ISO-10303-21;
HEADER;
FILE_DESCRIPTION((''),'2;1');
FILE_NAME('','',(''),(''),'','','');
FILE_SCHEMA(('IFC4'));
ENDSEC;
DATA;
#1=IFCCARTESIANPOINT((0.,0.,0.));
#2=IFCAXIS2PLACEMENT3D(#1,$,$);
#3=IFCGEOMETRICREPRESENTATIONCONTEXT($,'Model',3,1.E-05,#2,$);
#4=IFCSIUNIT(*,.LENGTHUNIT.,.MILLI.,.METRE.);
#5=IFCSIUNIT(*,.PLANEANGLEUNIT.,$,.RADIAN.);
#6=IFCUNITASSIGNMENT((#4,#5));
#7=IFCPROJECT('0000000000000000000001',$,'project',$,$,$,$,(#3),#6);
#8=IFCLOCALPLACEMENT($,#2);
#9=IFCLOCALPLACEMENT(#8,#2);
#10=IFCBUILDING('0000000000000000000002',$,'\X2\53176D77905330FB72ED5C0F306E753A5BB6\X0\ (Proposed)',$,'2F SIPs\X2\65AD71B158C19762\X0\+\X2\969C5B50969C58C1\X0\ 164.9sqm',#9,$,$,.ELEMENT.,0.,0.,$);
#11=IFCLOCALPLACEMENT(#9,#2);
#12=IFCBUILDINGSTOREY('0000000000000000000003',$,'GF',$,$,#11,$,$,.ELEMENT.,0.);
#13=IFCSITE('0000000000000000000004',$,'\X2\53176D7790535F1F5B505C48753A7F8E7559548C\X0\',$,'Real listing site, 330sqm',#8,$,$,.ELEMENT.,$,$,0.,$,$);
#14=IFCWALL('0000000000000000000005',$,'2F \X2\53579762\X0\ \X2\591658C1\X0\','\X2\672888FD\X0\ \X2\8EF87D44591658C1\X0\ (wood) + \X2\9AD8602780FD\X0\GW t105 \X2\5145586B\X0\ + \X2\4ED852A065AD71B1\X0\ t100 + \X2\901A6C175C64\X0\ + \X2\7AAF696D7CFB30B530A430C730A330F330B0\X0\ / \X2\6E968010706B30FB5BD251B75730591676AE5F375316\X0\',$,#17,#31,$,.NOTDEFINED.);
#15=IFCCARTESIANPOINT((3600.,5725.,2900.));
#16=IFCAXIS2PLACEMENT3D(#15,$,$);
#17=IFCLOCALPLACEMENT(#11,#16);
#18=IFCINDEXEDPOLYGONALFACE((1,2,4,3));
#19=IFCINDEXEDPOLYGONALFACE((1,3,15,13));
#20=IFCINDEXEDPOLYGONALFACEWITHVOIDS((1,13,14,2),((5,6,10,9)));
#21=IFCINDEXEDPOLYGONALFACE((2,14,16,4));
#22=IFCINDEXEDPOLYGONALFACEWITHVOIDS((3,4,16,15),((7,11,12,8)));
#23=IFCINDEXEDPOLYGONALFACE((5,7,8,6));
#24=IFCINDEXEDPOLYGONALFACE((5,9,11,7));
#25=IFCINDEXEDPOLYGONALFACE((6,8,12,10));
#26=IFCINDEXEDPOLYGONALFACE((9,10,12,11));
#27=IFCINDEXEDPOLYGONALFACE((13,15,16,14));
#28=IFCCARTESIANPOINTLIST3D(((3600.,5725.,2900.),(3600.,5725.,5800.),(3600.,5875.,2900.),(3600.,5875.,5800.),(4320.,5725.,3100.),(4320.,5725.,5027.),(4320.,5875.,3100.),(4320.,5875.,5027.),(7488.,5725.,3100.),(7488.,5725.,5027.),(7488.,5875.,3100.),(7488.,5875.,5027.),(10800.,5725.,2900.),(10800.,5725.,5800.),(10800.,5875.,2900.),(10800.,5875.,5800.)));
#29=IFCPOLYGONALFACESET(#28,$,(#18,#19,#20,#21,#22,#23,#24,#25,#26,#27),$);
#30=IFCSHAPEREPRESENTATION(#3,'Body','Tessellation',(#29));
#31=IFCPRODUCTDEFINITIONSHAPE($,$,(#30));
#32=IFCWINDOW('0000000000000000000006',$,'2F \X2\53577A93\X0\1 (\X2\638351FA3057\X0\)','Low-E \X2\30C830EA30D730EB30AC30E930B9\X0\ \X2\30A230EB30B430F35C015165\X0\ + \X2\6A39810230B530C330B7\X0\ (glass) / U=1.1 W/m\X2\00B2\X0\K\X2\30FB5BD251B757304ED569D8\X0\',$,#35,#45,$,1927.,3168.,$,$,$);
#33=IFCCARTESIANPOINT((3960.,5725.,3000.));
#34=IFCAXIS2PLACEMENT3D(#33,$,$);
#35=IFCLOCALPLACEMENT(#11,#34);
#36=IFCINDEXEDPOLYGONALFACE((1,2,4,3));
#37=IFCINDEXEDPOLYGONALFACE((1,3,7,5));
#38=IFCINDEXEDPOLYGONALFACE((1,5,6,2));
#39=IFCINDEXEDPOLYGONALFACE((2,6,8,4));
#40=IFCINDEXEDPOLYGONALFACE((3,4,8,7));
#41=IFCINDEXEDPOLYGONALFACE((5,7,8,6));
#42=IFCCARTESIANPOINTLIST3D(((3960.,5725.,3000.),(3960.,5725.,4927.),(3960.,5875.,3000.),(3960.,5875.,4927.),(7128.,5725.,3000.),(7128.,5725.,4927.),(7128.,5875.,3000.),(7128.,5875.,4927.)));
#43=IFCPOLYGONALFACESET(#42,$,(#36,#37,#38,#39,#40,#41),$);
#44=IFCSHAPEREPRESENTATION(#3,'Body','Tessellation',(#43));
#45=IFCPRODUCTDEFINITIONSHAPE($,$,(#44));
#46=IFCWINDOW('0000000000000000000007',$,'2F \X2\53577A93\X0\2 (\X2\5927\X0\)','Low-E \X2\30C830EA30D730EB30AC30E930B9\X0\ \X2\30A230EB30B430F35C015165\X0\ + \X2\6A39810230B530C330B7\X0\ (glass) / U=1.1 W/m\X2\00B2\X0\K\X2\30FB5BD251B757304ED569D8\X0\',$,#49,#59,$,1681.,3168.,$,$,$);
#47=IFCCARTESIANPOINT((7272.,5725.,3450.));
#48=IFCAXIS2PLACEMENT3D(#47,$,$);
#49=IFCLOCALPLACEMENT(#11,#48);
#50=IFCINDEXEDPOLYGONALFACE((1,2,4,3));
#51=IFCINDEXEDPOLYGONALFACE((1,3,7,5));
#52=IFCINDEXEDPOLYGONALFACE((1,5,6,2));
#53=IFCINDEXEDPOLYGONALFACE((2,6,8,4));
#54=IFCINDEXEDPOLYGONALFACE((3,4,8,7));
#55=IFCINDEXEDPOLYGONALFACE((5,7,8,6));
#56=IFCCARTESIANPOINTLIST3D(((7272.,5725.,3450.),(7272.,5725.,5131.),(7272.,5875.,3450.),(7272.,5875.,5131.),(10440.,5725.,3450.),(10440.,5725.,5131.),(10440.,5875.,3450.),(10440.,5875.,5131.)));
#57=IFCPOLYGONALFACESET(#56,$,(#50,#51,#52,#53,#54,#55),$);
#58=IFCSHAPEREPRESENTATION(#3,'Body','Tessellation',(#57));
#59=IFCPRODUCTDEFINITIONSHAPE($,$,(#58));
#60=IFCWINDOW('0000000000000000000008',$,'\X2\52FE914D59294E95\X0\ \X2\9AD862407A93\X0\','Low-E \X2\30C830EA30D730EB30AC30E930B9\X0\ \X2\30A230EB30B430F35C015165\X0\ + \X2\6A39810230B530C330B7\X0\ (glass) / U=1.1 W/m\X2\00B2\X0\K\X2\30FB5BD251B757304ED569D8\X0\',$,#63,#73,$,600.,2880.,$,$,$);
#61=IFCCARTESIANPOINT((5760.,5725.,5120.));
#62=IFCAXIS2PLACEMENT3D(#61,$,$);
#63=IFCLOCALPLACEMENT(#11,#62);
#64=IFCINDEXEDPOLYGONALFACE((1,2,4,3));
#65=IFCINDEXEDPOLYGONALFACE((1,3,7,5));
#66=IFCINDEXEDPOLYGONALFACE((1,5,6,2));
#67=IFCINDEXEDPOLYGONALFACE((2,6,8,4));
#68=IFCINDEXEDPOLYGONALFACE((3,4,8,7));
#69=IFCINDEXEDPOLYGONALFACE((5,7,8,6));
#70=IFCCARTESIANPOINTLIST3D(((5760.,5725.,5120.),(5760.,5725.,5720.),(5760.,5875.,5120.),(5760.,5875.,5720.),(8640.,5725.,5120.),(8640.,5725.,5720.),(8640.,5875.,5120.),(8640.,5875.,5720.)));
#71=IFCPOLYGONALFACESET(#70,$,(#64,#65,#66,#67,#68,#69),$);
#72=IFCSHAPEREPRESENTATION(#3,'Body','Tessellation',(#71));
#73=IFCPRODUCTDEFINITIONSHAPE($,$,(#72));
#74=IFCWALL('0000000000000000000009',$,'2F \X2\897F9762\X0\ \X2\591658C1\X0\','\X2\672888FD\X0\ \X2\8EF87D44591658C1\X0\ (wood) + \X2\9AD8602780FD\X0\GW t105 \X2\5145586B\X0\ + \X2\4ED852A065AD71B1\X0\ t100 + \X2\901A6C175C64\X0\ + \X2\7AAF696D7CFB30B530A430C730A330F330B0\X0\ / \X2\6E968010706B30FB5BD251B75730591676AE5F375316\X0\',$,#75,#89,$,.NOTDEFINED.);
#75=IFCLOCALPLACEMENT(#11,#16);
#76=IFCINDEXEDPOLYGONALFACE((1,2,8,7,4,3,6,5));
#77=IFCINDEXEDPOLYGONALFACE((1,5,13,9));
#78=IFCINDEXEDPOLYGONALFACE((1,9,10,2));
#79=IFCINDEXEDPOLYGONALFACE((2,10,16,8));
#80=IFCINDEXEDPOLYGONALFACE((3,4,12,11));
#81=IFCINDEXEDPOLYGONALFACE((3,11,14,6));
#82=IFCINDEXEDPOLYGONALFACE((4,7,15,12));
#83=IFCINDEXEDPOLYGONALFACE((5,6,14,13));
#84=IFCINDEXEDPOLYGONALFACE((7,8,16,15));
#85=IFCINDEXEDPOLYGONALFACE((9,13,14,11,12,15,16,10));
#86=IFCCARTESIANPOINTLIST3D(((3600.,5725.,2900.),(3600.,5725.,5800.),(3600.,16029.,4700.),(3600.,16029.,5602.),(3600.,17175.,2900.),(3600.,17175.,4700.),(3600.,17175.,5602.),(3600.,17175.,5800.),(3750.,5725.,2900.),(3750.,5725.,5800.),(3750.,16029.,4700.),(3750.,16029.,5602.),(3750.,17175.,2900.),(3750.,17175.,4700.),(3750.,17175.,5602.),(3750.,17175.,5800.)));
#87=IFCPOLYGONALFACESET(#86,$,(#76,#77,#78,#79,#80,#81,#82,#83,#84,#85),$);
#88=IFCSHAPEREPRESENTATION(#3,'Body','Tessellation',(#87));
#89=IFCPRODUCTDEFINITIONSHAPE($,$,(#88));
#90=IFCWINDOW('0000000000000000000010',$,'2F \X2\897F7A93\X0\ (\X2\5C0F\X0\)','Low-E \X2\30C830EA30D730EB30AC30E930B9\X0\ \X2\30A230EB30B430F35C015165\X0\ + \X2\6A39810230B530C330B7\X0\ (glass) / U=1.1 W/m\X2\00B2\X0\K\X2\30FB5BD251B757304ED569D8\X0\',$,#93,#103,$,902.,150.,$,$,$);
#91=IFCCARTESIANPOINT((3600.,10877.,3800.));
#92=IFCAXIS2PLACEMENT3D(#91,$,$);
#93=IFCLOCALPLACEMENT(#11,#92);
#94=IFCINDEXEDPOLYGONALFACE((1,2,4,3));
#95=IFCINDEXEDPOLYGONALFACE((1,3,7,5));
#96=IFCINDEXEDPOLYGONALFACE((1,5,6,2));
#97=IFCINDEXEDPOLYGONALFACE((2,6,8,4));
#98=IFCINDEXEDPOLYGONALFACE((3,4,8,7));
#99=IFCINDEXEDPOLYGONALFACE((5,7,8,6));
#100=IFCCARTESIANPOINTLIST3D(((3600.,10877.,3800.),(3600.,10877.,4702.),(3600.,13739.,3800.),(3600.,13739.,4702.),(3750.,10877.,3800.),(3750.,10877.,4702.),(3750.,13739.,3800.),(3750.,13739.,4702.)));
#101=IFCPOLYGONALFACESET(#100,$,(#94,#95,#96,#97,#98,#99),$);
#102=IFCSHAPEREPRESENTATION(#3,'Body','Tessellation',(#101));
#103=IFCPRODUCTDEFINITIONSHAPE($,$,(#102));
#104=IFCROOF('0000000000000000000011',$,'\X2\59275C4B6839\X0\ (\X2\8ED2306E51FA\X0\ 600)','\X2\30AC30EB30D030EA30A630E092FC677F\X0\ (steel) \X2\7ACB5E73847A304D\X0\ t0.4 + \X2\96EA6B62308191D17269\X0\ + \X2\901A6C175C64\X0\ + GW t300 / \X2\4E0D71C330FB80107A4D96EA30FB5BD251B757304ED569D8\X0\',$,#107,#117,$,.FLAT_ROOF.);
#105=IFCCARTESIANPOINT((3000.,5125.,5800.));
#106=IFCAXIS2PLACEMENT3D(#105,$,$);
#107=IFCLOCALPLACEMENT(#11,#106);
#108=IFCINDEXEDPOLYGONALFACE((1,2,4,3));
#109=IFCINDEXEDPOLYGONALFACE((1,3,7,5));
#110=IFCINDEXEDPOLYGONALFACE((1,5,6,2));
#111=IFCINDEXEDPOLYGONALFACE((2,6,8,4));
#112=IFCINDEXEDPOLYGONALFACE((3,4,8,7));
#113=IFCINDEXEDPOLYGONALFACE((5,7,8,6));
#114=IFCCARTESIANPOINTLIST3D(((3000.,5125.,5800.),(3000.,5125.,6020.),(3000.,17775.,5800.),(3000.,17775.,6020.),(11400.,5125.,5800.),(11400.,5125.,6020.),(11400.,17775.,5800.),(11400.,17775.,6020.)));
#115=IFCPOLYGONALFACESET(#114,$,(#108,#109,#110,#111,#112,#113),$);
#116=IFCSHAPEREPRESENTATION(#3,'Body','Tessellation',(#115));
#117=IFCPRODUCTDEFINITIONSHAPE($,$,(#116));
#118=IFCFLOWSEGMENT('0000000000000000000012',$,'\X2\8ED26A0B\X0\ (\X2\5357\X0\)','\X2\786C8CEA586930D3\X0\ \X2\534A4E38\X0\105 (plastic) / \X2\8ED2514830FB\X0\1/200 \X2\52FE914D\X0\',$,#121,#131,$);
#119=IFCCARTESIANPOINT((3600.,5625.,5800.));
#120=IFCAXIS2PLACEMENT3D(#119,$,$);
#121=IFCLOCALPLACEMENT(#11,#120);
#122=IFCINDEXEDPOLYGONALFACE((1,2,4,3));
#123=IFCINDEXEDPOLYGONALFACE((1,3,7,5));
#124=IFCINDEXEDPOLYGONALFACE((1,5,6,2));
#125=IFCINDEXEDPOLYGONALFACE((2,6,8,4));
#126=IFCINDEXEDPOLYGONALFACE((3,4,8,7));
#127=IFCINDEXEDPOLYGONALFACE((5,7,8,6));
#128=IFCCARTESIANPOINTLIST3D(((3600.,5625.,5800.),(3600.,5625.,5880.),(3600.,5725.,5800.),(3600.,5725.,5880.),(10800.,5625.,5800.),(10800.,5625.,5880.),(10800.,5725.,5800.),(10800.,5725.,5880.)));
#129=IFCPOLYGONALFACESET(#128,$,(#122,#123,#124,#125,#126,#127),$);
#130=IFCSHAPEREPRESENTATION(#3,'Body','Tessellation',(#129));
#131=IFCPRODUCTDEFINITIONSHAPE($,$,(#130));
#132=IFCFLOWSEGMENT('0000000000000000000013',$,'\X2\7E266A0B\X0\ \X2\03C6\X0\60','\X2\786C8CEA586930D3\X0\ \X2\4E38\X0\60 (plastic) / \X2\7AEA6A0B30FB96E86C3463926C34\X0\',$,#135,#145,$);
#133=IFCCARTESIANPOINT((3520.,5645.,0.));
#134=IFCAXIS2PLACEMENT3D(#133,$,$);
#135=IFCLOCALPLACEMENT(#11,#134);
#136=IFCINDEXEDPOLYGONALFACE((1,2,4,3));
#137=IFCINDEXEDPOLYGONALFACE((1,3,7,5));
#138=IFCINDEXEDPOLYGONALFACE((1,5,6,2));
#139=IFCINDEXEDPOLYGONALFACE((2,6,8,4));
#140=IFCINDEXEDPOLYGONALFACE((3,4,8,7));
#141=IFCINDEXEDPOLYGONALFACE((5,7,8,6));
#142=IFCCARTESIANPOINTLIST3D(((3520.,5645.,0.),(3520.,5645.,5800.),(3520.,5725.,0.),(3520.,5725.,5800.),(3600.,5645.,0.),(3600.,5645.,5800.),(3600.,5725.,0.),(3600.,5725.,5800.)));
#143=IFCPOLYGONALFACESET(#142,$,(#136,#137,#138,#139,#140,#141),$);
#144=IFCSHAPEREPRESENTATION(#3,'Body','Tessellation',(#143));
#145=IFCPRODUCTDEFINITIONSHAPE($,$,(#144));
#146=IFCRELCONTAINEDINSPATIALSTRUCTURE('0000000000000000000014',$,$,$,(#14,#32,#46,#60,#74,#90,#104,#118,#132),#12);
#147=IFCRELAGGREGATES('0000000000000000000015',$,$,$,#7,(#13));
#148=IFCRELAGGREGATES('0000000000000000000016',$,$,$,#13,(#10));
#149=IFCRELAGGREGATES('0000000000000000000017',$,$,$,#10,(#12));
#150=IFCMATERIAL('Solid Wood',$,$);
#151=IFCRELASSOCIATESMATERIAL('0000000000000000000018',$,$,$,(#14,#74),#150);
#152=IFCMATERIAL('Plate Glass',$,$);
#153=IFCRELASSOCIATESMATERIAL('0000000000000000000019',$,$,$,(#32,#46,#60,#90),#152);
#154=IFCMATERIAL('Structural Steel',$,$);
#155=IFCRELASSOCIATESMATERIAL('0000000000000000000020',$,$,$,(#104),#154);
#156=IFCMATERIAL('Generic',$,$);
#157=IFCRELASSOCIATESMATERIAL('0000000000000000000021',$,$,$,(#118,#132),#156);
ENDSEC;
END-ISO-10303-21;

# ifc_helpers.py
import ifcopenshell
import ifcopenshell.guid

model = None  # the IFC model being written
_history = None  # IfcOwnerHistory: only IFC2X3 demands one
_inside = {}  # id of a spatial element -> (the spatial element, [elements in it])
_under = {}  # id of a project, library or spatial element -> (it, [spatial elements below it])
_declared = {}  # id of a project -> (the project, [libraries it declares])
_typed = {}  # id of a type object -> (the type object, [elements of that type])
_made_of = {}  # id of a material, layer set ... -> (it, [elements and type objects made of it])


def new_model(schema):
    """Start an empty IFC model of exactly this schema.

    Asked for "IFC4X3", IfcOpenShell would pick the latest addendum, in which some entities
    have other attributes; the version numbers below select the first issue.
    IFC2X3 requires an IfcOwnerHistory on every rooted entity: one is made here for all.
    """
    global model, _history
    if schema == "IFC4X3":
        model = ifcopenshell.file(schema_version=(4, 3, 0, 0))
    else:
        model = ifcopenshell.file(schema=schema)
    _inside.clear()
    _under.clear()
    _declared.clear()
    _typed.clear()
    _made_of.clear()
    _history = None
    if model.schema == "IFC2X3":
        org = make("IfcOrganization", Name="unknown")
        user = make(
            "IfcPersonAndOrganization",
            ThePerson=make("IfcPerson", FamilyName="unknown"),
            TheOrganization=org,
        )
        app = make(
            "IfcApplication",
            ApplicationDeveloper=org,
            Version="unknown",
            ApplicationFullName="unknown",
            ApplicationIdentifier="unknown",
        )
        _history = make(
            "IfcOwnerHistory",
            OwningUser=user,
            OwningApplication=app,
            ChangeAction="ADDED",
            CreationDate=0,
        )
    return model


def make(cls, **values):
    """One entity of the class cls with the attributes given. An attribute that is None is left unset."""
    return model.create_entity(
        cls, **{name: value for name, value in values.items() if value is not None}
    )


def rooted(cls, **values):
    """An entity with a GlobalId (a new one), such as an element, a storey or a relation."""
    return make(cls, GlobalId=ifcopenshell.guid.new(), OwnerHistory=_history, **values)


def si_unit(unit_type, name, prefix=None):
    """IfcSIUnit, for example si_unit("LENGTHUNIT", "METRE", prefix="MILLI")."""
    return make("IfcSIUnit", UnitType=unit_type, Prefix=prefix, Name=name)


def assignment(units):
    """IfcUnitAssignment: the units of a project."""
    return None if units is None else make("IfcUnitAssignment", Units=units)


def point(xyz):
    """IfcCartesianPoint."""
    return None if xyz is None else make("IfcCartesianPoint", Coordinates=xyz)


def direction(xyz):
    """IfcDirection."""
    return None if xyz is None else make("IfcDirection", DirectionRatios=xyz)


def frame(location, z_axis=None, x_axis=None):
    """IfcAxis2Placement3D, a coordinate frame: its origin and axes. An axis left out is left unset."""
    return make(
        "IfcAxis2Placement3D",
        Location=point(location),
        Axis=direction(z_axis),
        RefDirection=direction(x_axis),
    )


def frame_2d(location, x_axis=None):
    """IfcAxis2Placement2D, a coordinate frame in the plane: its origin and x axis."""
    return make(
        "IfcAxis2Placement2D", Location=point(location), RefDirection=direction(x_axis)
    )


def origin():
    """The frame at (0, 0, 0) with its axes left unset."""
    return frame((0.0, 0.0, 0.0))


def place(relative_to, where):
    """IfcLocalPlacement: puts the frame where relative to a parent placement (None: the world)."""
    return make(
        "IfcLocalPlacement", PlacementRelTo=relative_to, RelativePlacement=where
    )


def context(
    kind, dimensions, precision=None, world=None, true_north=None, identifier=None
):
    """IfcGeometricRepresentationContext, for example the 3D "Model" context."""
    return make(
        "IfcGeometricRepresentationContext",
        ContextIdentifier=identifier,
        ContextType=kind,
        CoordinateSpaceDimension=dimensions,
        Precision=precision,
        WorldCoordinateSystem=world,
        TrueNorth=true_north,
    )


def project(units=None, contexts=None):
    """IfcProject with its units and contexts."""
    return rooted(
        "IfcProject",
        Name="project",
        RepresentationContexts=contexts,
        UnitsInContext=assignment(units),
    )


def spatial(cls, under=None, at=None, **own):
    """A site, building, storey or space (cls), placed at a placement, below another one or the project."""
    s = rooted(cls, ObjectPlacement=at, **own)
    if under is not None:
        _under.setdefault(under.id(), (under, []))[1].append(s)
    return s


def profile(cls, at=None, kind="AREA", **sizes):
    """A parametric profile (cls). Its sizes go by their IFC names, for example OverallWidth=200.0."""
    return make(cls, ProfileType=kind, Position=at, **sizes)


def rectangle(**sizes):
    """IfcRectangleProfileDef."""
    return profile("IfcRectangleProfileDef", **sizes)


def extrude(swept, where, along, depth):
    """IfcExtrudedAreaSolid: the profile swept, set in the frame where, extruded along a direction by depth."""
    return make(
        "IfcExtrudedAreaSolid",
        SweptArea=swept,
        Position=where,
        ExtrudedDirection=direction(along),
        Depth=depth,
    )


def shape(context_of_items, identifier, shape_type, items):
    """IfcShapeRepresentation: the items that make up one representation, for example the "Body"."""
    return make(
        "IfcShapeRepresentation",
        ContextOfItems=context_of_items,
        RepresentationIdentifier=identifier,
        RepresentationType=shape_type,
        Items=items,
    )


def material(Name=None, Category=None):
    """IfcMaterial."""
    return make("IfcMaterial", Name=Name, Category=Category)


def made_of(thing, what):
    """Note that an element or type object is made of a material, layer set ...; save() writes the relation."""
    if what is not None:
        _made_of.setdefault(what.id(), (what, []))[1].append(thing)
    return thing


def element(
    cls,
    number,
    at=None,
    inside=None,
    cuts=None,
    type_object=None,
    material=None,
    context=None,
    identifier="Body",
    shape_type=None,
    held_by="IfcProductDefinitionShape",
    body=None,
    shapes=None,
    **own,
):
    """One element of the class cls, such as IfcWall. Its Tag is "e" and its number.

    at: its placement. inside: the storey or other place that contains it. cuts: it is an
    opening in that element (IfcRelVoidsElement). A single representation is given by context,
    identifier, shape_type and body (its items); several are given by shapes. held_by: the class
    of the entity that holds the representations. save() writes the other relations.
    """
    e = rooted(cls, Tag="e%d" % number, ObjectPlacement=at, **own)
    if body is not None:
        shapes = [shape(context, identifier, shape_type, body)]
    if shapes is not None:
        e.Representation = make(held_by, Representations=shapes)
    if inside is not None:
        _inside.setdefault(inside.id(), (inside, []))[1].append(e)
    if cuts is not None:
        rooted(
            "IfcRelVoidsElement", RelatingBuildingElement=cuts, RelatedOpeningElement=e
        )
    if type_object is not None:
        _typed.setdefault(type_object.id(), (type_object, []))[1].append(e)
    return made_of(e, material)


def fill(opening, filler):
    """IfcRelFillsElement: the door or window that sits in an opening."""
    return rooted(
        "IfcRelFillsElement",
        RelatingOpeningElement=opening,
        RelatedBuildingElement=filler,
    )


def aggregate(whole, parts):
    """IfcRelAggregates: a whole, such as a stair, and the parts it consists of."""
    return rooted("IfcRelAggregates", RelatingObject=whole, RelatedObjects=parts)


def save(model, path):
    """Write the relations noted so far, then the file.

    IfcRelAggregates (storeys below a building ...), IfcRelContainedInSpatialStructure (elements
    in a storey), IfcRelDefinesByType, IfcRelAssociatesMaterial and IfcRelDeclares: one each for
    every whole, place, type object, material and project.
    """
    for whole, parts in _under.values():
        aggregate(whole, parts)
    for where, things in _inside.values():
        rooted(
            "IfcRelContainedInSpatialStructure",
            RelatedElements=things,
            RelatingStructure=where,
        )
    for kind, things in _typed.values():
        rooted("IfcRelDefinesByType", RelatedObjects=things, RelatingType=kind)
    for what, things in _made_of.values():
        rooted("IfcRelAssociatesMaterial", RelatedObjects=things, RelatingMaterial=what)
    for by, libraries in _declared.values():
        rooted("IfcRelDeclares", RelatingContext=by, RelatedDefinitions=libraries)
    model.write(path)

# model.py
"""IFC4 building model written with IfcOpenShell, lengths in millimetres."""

from ifc_helpers import new_model, si_unit, frame, frame_2d, origin, place, context, project, spatial, rectangle, extrude, material, element, fill, save


model = new_model("IFC4")

# Units and contexts
model_context = context("Model", 3, precision=1e-05, world=origin())
ifc_project = project(units=[si_unit("LENGTHUNIT", "METRE", prefix="MILLI"), si_unit("PLANEANGLEUNIT", "RADIAN")], contexts=[model_context])

# Site, building, storey
site_placement = place(None, origin())
site = spatial("IfcSite", under=ifc_project, at=site_placement, Name="北海道弟子屈町美留和", ObjectType="Real listing site, 330sqm", CompositionType="ELEMENT", RefElevation=0.0)
building_placement = place(site_placement, origin())
building = spatial("IfcBuilding", under=site, at=building_placement, Name="北海道・狭小の町家 (Proposed)", ObjectType="2F SIPs断熱壁面+障子障壁 164.9sqm", CompositionType="ELEMENT", ElevationOfRefHeight=0.0, ElevationOfTerrain=0.0)
storey_placement = place(building_placement, origin())
storey = spatial("IfcBuildingStorey", under=building, at=storey_placement, Name="GF", CompositionType="ELEMENT", Elevation=0.0)

# Shared definitions
ifc_material_1 = material(Name="Solid Wood")

# Shared definitions
ifc_material_2 = material(Name="Plate Glass")

# Wall, openings, windows
wall_1_placement = place(storey_placement, frame((3600.0, 5725.0, 2900.0)))
wall_1 = element("IfcWall", 1, at=wall_1_placement, inside=storey, material=ifc_material_1, Name="2F 南面 外壁", Description="木製 軸組外壁 (wood) + 高性能GW t105 充填 + 付加断熱 t100 + 通気層 + 窯業系サイディング / 準耐火・寒冷地外皮強化", PredefinedType="NOTDEFINED", context=model_context, shape_type="SweptSolid", body=[
    extrude(rectangle(XDim=7200.0, YDim=150.0, at=frame_2d((3600.0, 75.0))), frame((3600.0, 5725.0, 2900.0)), (0.0, 0.0, 1.0), 2900.0),
])
opening_1_placement = place(storey_placement, frame((3960.0, 5725.0, 3000.0)))
opening_1 = element("IfcOpeningElement", 2, at=opening_1_placement, cuts=wall_1, PredefinedType="NOTDEFINED", context=model_context, shape_type="SweptSolid", body=[
    extrude(rectangle(XDim=3168.0, YDim=150.0, at=frame_2d((1584.0, 75.0))), frame((3960.0, 5725.0, 3000.0)), (0.0, 0.0, 1.0), 1927.0),
])
opening_2_placement = place(storey_placement, frame((7272.0, 5725.0, 3450.0)))
opening_2 = element("IfcOpeningElement", 3, at=opening_2_placement, cuts=wall_1, PredefinedType="NOTDEFINED", context=model_context, shape_type="SweptSolid", body=[
    extrude(rectangle(XDim=3168.0, YDim=150.0, at=frame_2d((1584.0, 75.0))), frame((7272.0, 5725.0, 3450.0)), (0.0, 0.0, 1.0), 1681.0),
])
opening_3_placement = place(storey_placement, frame((5760.0, 5725.0, 5120.0)))
opening_3 = element("IfcOpeningElement", 4, at=opening_3_placement, cuts=wall_1, PredefinedType="NOTDEFINED", context=model_context, shape_type="SweptSolid", body=[
    extrude(rectangle(XDim=2880.0, YDim=150.0, at=frame_2d((1440.0, 75.0))), frame((5760.0, 5725.0, 5120.0)), (0.0, 0.0, 1.0), 600.0),
])
window_1_placement = place(storey_placement, frame((3960.0, 5725.0, 3000.0)))
window_1 = element("IfcWindow", 5, at=window_1_placement, inside=storey, material=ifc_material_2, Name="2F 南窓1 (掃出し)", Description="Low-E トリプルガラス アルゴン封入 + 樹脂サッシ (glass) / U=1.1 W/m²K・寒冷地仕様", OverallHeight=1927.0, OverallWidth=3168.0, context=model_context, shape_type="SweptSolid", body=[
    extrude(rectangle(XDim=3168.0, YDim=150.0, at=frame_2d((1584.0, 75.0))), frame((3960.0, 5725.0, 3000.0)), (0.0, 0.0, 1.0), 1927.0),
])
fill(opening_1, window_1)
window_2_placement = place(storey_placement, frame((7272.0, 5725.0, 3450.0)))
window_2 = element("IfcWindow", 6, at=window_2_placement, inside=storey, material=ifc_material_2, Name="2F 南窓2 (大)", Description="Low-E トリプルガラス アルゴン封入 + 樹脂サッシ (glass) / U=1.1 W/m²K・寒冷地仕様", OverallHeight=1681.0, OverallWidth=3168.0, context=model_context, shape_type="SweptSolid", body=[
    extrude(rectangle(XDim=3168.0, YDim=150.0, at=frame_2d((1584.0, 75.0))), frame((7272.0, 5725.0, 3450.0)), (0.0, 0.0, 1.0), 1681.0),
])
fill(opening_2, window_2)
window_3_placement = place(storey_placement, frame((5760.0, 5725.0, 5120.0)))
window_3 = element("IfcWindow", 7, at=window_3_placement, inside=storey, material=ifc_material_2, Name="勾配天井 高所窓", Description="Low-E トリプルガラス アルゴン封入 + 樹脂サッシ (glass) / U=1.1 W/m²K・寒冷地仕様", OverallHeight=600.0, OverallWidth=2880.0, context=model_context, shape_type="SweptSolid", body=[
    extrude(rectangle(XDim=2880.0, YDim=150.0, at=frame_2d((1440.0, 75.0))), frame((5760.0, 5725.0, 5120.0)), (0.0, 0.0, 1.0), 600.0),
])
fill(opening_3, window_3)

# Wall, opening, window
wall_2_placement = place(storey_placement, frame((3600.0, 5725.0, 2900.0)))
wall_2 = element("IfcWall", 8, at=wall_2_placement, inside=storey, material=ifc_material_1, Name="2F 西面 外壁", Description="木製 軸組外壁 (wood) + 高性能GW t105 充填 + 付加断熱 t100 + 通気層 + 窯業系サイディング / 準耐火・寒冷地外皮強化", PredefinedType="NOTDEFINED", context=model_context, shape_type="SweptSolid", body=[
    extrude(rectangle(XDim=150.0, YDim=11450.0, at=frame_2d((75.0, 5725.0))), frame((3600.0, 5725.0, 2900.0)), (0.0, 0.0, 1.0), 2900.0),
])
opening_4_placement = place(storey_placement, frame((3600.0, 10877.0, 3800.0)))
opening_4 = element("IfcOpeningElement", 9, at=opening_4_placement, cuts=wall_2, PredefinedType="NOTDEFINED", context=model_context, shape_type="SweptSolid", body=[
    extrude(rectangle(XDim=150.0, YDim=2862.0, at=frame_2d((75.0, 1431.0))), frame((3600.0, 10877.0, 3800.0)), (0.0, 0.0, 1.0), 902.0),
])
window_4_placement = place(storey_placement, frame((3600.0, 10877.0, 3800.0)))
window_4 = element("IfcWindow", 10, at=window_4_placement, inside=storey, material=ifc_material_2, Name="2F 西窓 (小)", Description="Low-E トリプルガラス アルゴン封入 + 樹脂サッシ (glass) / U=1.1 W/m²K・寒冷地仕様", OverallHeight=902.0, OverallWidth=150.0, context=model_context, shape_type="SweptSolid", body=[
    extrude(rectangle(XDim=150.0, YDim=2862.0, at=frame_2d((75.0, 1431.0))), frame((3600.0, 10877.0, 3800.0)), (0.0, 0.0, 1.0), 902.0),
])
fill(opening_4, window_4)

# Roof
ifc_material_3 = material(Name="Structural Steel")
roof_placement = place(storey_placement, frame((3000.0, 5125.0, 5800.0)))
element("IfcRoof", 11, at=roof_placement, inside=storey, material=ifc_material_3, Name="大屋根 (軒の出 600)", Description="ガルバリウム鋼板 (steel) 立平葺き t0.4 + 雪止め金物 + 通気層 + GW t300 / 不燃・耐積雪・寒冷地仕様", PredefinedType="FLAT_ROOF", context=model_context, shape_type="SweptSolid", body=[
    extrude(rectangle(XDim=8400.0, YDim=12650.0, at=frame_2d((4200.0, 6325.0))), frame((3000.0, 5125.0, 5800.0)), (0.0, 0.0, 1.0), 220.0),
])

# Flow segments
ifc_material_4 = material(Name="Generic")
flow_segment_1_placement = place(storey_placement, frame((3600.0, 5625.0, 5800.0)))
element("IfcFlowSegment", 12, at=flow_segment_1_placement, inside=storey, material=ifc_material_4, Name="軒樋 (南)", Description="硬質塩ビ 半丸105 (plastic) / 軒先・1/200 勾配", context=model_context, shape_type="SweptSolid", body=[
    extrude(rectangle(XDim=7200.0, YDim=100.0, at=frame_2d((3600.0, 50.0))), frame((3600.0, 5625.0, 5800.0)), (0.0, 0.0, 1.0), 80.0),
])
flow_segment_2_placement = place(storey_placement, frame((3520.0, 5645.0, 0.0)))
element("IfcFlowSegment", 13, at=flow_segment_2_placement, inside=storey, material=ifc_material_4, Name="縦樋 φ60", Description="硬質塩ビ 丸60 (plastic) / 竪樋・雨水排水", context=model_context, shape_type="SweptSolid", body=[
    extrude(rectangle(XDim=80.0, YDim=80.0, at=frame_2d((40.0, 40.0))), frame((3520.0, 5645.0, 0.0)), (0.0, 0.0, 1.0), 5800.0),
])

save(model, "model.ifc")
